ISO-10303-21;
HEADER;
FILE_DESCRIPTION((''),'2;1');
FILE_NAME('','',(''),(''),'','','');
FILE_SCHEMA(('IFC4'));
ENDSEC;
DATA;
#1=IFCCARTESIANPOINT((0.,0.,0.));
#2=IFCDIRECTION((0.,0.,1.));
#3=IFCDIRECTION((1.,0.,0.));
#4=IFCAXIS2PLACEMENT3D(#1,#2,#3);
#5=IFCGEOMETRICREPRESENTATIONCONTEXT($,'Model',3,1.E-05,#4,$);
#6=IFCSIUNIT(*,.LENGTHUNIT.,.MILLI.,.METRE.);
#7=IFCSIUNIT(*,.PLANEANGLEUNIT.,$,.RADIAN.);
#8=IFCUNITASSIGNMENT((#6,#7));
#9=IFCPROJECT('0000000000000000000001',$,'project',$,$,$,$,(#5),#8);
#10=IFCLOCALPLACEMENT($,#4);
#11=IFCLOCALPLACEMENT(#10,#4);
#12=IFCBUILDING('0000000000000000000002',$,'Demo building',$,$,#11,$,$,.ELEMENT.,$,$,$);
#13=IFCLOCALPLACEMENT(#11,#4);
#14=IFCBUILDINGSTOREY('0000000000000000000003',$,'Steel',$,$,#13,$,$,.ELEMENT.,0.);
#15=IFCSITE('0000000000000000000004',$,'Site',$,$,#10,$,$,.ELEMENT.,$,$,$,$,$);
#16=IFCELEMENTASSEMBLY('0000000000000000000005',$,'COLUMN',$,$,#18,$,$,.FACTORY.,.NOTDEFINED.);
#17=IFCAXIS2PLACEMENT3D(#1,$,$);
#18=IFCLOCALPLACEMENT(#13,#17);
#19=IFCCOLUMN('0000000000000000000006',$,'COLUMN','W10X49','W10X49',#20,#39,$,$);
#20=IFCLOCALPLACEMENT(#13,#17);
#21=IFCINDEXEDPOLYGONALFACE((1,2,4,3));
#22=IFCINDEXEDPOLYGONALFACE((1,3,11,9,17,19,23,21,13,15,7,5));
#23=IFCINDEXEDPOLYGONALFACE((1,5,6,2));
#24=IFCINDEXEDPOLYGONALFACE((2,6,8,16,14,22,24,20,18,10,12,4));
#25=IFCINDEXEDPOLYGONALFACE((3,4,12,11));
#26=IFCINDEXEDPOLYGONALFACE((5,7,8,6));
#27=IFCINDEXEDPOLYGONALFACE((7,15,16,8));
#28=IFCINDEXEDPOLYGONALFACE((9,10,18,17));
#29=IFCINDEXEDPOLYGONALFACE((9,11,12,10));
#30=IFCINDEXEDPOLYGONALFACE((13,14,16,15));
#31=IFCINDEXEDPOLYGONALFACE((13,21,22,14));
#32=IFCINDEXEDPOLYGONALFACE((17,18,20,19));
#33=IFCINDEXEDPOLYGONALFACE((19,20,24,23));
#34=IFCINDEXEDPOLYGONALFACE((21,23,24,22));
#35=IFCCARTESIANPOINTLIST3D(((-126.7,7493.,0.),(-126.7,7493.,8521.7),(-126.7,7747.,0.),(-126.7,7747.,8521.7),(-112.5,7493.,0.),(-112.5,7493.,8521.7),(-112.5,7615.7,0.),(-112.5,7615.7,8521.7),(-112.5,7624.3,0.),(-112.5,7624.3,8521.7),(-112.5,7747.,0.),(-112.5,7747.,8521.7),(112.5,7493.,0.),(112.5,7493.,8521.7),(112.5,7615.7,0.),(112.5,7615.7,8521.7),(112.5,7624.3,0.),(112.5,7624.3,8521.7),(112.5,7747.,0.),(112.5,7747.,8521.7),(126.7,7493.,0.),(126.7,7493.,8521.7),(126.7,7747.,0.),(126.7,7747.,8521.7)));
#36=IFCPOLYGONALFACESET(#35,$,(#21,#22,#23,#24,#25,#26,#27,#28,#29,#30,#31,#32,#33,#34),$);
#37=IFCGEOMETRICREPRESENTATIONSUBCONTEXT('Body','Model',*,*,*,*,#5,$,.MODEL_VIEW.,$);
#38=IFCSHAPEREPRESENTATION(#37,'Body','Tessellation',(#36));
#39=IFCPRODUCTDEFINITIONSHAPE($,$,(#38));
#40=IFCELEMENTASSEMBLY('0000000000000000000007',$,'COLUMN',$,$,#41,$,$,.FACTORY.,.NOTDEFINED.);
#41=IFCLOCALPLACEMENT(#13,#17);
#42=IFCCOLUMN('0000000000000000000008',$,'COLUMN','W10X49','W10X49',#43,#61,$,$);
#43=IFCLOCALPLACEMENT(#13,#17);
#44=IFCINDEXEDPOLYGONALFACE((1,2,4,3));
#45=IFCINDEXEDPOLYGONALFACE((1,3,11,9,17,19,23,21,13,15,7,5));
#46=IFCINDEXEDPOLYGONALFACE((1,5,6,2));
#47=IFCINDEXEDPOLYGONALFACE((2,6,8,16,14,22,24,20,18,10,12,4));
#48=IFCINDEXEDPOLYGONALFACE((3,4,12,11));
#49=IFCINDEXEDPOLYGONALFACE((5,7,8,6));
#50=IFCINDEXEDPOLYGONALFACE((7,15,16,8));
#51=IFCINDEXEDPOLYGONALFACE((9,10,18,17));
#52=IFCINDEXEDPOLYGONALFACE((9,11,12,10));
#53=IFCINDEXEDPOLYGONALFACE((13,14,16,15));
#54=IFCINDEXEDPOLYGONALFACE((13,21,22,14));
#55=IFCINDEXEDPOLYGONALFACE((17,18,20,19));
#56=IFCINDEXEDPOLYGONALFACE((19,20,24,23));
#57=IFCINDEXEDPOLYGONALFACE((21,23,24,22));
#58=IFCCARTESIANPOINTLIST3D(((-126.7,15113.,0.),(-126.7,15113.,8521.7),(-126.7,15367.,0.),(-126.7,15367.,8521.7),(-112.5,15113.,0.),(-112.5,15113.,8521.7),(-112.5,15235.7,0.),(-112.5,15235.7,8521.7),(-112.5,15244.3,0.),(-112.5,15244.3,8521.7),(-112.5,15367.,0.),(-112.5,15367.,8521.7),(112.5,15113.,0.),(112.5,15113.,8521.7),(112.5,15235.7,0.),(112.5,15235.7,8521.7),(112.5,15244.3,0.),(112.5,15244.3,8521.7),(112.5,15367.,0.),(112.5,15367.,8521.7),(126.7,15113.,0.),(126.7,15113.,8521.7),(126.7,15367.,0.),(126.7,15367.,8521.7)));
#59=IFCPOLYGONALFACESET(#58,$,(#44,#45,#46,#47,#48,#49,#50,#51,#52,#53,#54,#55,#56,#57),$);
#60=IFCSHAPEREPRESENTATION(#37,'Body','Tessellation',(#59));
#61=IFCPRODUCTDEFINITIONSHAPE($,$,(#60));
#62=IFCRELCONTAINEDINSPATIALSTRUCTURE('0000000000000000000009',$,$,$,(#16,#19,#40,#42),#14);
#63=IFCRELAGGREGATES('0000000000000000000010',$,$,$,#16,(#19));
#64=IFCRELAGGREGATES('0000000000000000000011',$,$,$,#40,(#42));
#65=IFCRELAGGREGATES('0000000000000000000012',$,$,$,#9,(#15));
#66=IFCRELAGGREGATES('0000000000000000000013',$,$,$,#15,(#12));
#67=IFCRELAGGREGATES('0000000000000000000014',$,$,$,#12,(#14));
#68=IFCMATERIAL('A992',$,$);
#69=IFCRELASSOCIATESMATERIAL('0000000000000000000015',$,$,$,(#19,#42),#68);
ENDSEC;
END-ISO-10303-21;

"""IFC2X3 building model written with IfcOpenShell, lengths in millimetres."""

from ifc_helpers import new_model, si_unit, frame, origin, origin_with_axes, origin_2d, place, context, subcontext, project, spatial, i_section, extrude, material, element, aggregate, save


model = new_model("IFC2X3")

# Units and contexts
model_context = context("Model", 3, precision=1e-05, world=origin_with_axes())
body_context = subcontext(model_context, "Body", "Model", "MODEL_VIEW")
ifc_project = project(units=[si_unit("LENGTHUNIT", "METRE", prefix="MILLI"), si_unit("PLANEANGLEUNIT", "RADIAN")], contexts=[model_context])

# Site, building, storey
site_placement = place(None, origin_with_axes())
site = spatial("IfcSite", under=ifc_project, at=site_placement, Name="Site", CompositionType="ELEMENT")
building_placement = place(site_placement, origin_with_axes())
building = spatial("IfcBuilding", under=site, at=building_placement, Name="Demo building", CompositionType="ELEMENT")
placement = place(building_placement, origin_with_axes())
storey = spatial("IfcBuildingStorey", under=building, at=placement, Name="Steel", CompositionType="ELEMENT", Elevation=0.0)

# Element assemblies, columns
assembly_1 = element("IfcElementAssembly", 1, at=placement, inside=storey, Name="COLUMN", AssemblyPlace="FACTORY", PredefinedType="NOTDEFINED")
ifc_material_1 = material(Name="A992")
column_1_placement = place(placement, frame((0.0, 7620.0, 0.0), z_axis=(0.0, 0.0, 1.0), x_axis=(0.0, -1.0, 0.0)))
column_1 = element("IfcColumn", 2, at=column_1_placement, inside=storey, material=ifc_material_1, Name="COLUMN", Description="W10X49", ObjectType="W10X49", context=body_context, shape_type="SweptSolid", body=[
    extrude(i_section(OverallWidth=254.0, OverallDepth=253.5, WebThickness=8.6, FlangeThickness=14.2, at=origin_2d()), origin(), (0.0, 0.0, 1.0), 8521.7),
])
aggregate(assembly_1, [column_1])
assembly_2 = element("IfcElementAssembly", 3, at=placement, inside=storey, Name="COLUMN", AssemblyPlace="FACTORY", PredefinedType="NOTDEFINED")
column_2_placement = place(placement, frame((0.0, 15240.0, 0.0), z_axis=(0.0, 0.0, 1.0), x_axis=(0.0, -1.0, 0.0)))
column_2 = element("IfcColumn", 4, at=column_2_placement, inside=storey, material=ifc_material_1, Name="COLUMN", Description="W10X49", ObjectType="W10X49", context=body_context, shape_type="SweptSolid", body=[
    extrude(i_section(OverallWidth=254.0, OverallDepth=253.5, WebThickness=8.6, FlangeThickness=14.2, at=origin_2d()), origin(), (0.0, 0.0, 1.0), 8521.7),
])

aggregate(assembly_2, [column_2])

save(model, "model.ifc")
